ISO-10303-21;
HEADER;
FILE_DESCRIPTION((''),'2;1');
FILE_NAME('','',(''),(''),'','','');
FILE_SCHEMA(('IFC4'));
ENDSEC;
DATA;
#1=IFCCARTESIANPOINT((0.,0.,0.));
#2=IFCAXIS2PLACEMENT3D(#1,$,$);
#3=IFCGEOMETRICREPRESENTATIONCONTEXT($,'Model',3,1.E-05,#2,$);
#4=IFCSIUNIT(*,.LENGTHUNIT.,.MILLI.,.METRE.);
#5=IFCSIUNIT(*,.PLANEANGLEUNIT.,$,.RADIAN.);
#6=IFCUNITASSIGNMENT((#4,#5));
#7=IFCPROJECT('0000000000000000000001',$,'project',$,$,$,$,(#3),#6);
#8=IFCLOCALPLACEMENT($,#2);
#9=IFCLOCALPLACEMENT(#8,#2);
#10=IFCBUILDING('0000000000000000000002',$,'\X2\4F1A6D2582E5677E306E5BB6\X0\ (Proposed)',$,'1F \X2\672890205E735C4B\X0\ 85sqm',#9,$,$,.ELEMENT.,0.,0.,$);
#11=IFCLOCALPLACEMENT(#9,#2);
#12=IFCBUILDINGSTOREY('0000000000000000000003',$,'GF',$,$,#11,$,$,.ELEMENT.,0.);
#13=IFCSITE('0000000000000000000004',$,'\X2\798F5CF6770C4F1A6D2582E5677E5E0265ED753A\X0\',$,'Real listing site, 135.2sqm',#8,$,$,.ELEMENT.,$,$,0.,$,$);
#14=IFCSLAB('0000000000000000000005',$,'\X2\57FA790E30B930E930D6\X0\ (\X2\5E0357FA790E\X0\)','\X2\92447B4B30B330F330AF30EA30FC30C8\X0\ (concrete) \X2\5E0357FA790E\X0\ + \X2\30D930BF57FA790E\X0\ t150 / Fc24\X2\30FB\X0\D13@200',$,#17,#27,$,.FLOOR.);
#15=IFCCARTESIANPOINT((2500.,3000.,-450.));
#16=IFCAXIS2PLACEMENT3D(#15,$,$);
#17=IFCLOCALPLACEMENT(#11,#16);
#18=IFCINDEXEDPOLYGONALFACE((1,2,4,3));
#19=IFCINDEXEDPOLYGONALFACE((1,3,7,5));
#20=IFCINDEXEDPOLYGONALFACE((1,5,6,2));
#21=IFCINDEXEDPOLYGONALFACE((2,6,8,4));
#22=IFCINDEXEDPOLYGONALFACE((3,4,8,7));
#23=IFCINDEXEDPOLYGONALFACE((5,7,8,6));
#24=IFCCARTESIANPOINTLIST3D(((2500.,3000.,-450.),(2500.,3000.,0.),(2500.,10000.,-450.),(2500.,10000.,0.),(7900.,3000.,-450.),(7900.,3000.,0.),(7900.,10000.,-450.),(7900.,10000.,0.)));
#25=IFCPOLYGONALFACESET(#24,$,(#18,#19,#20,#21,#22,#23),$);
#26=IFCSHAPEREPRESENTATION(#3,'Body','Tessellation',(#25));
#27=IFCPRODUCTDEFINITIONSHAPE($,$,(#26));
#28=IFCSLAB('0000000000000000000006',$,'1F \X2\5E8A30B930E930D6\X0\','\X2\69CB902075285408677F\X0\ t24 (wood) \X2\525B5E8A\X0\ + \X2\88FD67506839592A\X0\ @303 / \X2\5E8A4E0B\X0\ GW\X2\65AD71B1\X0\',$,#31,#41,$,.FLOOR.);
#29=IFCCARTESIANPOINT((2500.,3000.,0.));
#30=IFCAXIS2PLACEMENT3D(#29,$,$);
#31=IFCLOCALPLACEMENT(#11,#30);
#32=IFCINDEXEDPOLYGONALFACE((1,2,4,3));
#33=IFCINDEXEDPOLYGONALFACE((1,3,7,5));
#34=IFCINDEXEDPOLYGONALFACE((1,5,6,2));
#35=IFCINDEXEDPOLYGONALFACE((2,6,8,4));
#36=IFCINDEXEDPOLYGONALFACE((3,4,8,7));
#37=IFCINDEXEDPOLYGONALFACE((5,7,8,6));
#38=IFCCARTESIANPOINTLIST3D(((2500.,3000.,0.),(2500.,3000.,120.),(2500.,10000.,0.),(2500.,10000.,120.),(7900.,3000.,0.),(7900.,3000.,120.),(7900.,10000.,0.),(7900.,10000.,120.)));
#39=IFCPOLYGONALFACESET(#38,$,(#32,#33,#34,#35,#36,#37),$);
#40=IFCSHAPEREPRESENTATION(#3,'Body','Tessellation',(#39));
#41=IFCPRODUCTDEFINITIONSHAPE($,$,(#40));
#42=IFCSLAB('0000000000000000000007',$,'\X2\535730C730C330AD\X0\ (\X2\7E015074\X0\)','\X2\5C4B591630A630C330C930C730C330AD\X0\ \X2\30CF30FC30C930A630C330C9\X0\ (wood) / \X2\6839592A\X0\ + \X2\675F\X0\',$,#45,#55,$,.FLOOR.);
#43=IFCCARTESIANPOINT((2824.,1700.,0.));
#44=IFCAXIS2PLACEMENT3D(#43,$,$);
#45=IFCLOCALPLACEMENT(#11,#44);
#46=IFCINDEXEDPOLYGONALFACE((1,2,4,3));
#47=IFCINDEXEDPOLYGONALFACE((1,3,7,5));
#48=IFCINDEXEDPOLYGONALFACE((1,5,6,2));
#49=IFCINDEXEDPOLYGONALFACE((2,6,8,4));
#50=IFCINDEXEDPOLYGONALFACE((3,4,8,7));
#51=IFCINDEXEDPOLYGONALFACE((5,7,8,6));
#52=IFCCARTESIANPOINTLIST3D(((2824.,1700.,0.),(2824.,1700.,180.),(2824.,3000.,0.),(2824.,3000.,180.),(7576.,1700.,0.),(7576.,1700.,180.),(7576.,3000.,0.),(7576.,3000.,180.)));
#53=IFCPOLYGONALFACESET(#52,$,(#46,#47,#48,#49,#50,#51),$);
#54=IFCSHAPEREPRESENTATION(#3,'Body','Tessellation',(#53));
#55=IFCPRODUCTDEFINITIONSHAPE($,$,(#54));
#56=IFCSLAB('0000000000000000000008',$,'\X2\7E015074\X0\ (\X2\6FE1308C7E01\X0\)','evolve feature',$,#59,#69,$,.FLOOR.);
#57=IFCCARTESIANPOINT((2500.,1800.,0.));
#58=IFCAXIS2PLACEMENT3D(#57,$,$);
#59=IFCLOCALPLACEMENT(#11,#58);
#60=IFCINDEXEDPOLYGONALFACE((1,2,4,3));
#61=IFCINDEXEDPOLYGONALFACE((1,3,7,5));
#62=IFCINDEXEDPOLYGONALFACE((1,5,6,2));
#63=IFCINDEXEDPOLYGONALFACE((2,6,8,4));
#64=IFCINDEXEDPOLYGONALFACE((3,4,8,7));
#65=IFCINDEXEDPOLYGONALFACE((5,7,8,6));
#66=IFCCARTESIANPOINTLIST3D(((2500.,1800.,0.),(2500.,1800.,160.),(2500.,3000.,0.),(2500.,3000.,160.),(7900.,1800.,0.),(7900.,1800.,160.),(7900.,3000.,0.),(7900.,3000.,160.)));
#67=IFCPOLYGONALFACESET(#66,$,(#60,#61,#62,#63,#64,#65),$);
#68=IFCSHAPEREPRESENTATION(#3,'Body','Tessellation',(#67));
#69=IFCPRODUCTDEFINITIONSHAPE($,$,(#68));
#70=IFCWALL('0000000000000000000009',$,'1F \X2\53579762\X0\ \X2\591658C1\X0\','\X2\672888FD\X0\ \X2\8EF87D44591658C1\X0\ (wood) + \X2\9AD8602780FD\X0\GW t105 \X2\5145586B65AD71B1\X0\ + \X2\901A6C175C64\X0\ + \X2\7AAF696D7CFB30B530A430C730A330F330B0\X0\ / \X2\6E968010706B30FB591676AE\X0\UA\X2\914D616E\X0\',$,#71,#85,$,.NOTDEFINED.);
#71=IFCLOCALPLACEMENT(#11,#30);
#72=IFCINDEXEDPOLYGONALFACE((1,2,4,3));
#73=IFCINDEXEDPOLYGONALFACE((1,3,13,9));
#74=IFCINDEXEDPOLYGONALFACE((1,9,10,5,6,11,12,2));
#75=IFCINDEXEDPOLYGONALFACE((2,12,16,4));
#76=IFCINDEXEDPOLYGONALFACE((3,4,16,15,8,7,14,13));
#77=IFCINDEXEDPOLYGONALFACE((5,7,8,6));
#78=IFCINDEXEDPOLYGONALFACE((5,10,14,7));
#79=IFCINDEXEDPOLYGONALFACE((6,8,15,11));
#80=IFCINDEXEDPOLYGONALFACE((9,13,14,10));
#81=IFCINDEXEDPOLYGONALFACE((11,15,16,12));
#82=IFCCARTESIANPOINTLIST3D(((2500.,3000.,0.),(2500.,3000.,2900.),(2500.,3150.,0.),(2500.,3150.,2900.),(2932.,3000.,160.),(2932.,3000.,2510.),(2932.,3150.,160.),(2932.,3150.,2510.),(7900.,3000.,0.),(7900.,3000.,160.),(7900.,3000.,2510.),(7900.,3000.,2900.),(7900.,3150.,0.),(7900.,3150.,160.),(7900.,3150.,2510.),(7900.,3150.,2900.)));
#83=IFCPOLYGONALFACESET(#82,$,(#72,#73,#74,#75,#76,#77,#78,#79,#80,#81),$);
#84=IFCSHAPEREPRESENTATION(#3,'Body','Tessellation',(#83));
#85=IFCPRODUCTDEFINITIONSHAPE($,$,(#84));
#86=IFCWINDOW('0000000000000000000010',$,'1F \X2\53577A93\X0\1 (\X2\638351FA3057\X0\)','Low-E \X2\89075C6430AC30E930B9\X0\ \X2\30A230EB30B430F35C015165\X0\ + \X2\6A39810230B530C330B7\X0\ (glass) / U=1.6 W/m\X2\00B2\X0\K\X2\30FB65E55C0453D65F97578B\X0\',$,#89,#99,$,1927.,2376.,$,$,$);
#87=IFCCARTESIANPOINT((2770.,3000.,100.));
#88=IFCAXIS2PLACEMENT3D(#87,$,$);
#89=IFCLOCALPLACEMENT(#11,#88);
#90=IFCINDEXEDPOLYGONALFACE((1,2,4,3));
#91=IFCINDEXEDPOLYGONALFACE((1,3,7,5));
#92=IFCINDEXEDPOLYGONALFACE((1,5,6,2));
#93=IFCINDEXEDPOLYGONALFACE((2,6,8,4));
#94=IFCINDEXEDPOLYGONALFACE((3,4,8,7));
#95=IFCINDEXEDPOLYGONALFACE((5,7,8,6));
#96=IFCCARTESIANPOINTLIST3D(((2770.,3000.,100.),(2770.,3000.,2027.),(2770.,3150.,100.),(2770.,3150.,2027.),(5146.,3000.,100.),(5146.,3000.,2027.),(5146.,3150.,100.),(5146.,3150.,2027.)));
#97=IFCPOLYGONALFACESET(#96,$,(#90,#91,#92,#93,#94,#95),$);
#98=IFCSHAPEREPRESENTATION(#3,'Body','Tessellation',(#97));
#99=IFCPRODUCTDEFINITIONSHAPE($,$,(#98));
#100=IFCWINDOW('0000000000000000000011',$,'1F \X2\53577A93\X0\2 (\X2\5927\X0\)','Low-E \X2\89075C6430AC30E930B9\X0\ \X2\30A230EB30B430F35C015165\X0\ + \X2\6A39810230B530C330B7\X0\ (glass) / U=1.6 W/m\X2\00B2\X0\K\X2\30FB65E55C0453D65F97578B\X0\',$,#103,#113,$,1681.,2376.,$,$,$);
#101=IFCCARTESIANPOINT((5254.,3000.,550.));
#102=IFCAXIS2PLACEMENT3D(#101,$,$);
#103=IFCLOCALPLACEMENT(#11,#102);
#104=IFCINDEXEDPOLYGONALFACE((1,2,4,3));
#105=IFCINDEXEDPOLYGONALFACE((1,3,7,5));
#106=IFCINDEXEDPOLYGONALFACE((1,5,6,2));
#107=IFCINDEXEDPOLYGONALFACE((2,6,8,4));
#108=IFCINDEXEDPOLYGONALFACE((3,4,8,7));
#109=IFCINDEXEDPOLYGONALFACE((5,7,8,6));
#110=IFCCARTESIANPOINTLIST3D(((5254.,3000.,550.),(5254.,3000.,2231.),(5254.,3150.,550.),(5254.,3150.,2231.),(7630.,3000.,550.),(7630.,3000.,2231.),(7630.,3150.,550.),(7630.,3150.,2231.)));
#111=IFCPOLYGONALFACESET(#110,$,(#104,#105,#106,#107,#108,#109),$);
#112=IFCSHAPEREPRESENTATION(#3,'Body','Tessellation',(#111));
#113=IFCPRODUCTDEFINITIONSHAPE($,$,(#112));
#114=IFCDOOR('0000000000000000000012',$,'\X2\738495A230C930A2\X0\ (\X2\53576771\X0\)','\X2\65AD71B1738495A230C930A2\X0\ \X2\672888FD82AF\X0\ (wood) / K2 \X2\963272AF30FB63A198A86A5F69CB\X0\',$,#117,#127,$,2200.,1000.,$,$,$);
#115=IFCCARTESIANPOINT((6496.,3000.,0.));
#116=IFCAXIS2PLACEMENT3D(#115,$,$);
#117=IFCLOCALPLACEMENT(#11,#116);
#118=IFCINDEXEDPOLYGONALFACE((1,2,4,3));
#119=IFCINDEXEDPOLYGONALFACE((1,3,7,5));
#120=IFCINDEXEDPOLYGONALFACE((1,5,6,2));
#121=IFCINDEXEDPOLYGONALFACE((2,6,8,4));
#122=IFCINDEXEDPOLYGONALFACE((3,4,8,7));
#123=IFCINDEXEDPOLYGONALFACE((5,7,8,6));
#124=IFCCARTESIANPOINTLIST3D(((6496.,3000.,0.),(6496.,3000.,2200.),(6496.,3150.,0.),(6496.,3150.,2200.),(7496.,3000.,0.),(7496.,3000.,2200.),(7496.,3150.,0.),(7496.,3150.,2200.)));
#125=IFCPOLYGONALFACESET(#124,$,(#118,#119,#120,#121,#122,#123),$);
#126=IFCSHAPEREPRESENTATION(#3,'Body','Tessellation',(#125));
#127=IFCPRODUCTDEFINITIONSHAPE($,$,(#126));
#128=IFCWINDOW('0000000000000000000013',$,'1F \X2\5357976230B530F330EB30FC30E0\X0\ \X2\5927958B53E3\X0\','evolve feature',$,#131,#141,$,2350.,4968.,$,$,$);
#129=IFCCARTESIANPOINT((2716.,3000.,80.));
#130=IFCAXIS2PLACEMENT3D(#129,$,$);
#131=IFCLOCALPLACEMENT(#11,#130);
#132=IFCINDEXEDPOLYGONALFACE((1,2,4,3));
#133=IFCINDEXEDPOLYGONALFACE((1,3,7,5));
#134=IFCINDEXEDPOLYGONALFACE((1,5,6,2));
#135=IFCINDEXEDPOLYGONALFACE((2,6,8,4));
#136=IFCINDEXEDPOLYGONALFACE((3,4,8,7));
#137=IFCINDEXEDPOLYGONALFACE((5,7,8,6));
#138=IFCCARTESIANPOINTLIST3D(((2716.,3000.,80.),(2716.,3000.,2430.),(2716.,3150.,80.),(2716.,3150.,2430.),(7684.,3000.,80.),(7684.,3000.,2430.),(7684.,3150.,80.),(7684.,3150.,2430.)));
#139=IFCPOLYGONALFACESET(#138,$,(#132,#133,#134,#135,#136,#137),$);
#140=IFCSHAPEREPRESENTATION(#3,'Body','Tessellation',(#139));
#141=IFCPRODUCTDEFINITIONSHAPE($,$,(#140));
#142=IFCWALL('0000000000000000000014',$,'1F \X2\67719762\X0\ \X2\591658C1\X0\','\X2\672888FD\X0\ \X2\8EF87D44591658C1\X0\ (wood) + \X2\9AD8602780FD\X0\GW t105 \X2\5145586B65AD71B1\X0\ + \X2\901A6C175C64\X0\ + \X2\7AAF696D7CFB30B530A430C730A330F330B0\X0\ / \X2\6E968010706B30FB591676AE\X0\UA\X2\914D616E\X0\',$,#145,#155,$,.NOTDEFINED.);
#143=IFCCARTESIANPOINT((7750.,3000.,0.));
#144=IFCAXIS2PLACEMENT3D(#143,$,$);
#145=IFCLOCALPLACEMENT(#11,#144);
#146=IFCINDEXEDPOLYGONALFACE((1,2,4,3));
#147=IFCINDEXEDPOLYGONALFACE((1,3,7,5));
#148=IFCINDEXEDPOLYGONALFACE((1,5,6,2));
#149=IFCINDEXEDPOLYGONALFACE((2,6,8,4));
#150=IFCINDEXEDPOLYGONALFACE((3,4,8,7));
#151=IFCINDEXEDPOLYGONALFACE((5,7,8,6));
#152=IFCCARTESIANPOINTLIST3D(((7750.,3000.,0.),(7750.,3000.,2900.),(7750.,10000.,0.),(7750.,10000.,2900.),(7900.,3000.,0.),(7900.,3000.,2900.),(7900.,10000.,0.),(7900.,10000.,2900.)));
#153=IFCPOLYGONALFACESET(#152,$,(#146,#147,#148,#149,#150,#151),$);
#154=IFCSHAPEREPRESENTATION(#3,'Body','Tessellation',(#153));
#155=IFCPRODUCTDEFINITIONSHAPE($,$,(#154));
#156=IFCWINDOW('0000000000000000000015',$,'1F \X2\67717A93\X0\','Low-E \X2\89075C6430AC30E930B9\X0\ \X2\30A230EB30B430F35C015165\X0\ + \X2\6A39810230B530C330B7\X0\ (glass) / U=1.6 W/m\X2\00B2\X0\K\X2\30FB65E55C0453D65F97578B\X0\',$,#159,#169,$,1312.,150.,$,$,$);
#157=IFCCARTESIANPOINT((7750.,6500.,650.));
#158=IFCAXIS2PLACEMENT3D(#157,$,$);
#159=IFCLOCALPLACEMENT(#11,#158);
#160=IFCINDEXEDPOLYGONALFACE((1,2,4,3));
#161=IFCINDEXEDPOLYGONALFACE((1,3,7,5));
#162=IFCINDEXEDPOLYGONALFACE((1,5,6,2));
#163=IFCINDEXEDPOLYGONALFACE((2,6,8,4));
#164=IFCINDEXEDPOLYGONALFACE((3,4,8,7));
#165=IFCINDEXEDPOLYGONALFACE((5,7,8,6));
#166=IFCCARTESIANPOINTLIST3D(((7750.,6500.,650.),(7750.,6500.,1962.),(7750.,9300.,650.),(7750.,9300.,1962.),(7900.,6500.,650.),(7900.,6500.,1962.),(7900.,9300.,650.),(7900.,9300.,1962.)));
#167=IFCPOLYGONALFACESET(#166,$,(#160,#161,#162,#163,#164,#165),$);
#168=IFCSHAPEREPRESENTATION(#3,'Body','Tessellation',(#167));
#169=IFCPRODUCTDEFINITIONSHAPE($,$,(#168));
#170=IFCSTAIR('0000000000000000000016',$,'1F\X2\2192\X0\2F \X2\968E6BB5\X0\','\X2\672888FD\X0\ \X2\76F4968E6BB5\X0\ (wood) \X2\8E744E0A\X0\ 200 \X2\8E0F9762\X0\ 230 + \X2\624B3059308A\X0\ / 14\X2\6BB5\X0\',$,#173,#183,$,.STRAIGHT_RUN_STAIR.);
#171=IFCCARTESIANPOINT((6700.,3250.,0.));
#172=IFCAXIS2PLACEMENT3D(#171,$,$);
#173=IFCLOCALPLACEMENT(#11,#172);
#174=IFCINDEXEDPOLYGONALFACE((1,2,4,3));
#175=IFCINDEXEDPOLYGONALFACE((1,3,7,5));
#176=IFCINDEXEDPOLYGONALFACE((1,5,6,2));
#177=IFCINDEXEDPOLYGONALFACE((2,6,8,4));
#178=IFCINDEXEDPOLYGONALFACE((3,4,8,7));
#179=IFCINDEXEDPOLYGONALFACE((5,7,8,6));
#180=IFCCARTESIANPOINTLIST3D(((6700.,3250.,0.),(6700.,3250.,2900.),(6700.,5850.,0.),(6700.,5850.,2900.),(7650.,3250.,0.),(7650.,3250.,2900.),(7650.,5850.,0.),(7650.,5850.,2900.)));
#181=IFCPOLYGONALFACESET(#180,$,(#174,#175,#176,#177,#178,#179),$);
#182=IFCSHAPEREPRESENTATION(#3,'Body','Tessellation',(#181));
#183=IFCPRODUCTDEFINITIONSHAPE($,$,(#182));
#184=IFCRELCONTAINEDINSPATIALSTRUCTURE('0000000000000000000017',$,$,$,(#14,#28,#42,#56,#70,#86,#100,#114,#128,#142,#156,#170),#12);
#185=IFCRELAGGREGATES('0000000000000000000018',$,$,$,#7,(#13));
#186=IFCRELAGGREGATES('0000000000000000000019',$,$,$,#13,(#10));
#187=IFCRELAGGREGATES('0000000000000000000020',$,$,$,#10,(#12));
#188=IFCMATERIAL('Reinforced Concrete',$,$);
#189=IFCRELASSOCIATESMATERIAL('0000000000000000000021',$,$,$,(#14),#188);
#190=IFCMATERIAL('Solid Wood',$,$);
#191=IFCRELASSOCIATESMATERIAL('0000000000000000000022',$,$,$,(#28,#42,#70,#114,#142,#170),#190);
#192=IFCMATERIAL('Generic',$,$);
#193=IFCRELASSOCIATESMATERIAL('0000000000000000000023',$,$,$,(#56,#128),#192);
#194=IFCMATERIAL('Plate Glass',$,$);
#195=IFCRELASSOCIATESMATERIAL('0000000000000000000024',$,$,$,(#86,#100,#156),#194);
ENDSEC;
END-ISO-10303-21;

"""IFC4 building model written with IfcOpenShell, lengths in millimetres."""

from ifc_helpers import new_model, si_unit, frame, frame_2d, origin, place, context, project, spatial, rectangle, extrude, material, element, fill, save


model = new_model("IFC4")

# Units and contexts
model_context = context("Model", 3, precision=1e-05, world=origin())
ifc_project = project(units=[si_unit("LENGTHUNIT", "METRE", prefix="MILLI"), si_unit("PLANEANGLEUNIT", "RADIAN")], contexts=[model_context])

# Site, building, storey
site_placement = place(None, origin())
site = spatial("IfcSite", under=ifc_project, at=site_placement, Name="福島県会津若松市旭町", ObjectType="Real listing site, 135.2sqm", CompositionType="ELEMENT", RefElevation=0.0)
building_placement = place(site_placement, origin())
building = spatial("IfcBuilding", under=site, at=building_placement, Name="会津若松の家 (Proposed)", ObjectType="1F 木造平屋 85sqm", CompositionType="ELEMENT", ElevationOfRefHeight=0.0, ElevationOfTerrain=0.0)
storey_placement = place(building_placement, origin())
storey = spatial("IfcBuildingStorey", under=building, at=storey_placement, Name="GF", CompositionType="ELEMENT", Elevation=0.0)

# Slabs
ifc_material_1 = material(Name="Reinforced Concrete")
slab_1_placement = place(storey_placement, frame((2500.0, 3000.0, -450.0)))
element("IfcSlab", 1, at=slab_1_placement, inside=storey, material=ifc_material_1, Name="基礎スラブ (布基礎)", Description="鉄筋コンクリート (concrete) 布基礎 + ベタ基礎 t150 / Fc24・D13@200", PredefinedType="FLOOR", context=model_context, shape_type="SweptSolid", body=[
    extrude(rectangle(XDim=5400.0, YDim=7000.0, at=frame_2d((2700.0, 3500.0))), frame((2500.0, 3000.0, -450.0)), (0.0, 0.0, 1.0), 450.0),
])
ifc_material_2 = material(Name="Solid Wood")
slab_2_placement = place(storey_placement, frame((2500.0, 3000.0, 0.0)))
element("IfcSlab", 2, at=slab_2_placement, inside=storey, material=ifc_material_2, Name="1F 床スラブ", Description="構造用合板 t24 (wood) 剛床 + 製材根太 @303 / 床下 GW断熱", PredefinedType="FLOOR", context=model_context, shape_type="SweptSolid", body=[
    extrude(rectangle(XDim=5400.0, YDim=7000.0, at=frame_2d((2700.0, 3500.0))), frame((2500.0, 3000.0, 0.0)), (0.0, 0.0, 1.0), 120.0),
])
slab_3_placement = place(storey_placement, frame((2824.0, 1700.0, 0.0)))
element("IfcSlab", 3, at=slab_3_placement, inside=storey, material=ifc_material_2, Name="南デッキ (縁側)", Description="屋外ウッドデッキ ハードウッド (wood) / 根太 + 束", PredefinedType="FLOOR", context=model_context, shape_type="SweptSolid", body=[
    extrude(rectangle(XDim=4752.0, YDim=1300.0, at=frame_2d((2376.0, 650.0))), frame((2824.0, 1700.0, 0.0)), (0.0, 0.0, 1.0), 180.0),
])
ifc_material_3 = material(Name="Generic")
slab_4_placement = place(storey_placement, frame((2500.0, 1800.0, 0.0)))
element("IfcSlab", 4, at=slab_4_placement, inside=storey, material=ifc_material_3, Name="縁側 (濡れ縁)", Description="evolve feature", PredefinedType="FLOOR", context=model_context, shape_type="SweptSolid", body=[
    extrude(rectangle(XDim=5400.0, YDim=1200.0, at=frame_2d((2700.0, 600.0))), frame((2500.0, 1800.0, 0.0)), (0.0, 0.0, 1.0), 160.0),
])

# Wall, openings, windows, door
wall_1_placement = place(storey_placement, frame((2500.0, 3000.0, 0.0)))
wall_1 = element("IfcWall", 5, at=wall_1_placement, inside=storey, material=ifc_material_2, Name="1F 南面 外壁", Description="木製 軸組外壁 (wood) + 高性能GW t105 充填断熱 + 通気層 + 窯業系サイディング / 準耐火・外皮UA配慮", PredefinedType="NOTDEFINED", context=model_context, shape_type="SweptSolid", body=[
    extrude(rectangle(XDim=5400.0, YDim=150.0, at=frame_2d((2700.0, 75.0))), frame((2500.0, 3000.0, 0.0)), (0.0, 0.0, 1.0), 2900.0),
])
opening_1_placement = place(storey_placement, frame((2770.0, 3000.0, 100.0)))
opening_1 = element("IfcOpeningElement", 6, at=opening_1_placement, cuts=wall_1, PredefinedType="NOTDEFINED", context=model_context, shape_type="SweptSolid", body=[
    extrude(rectangle(XDim=2376.0, YDim=150.0, at=frame_2d((1188.0, 75.0))), frame((2770.0, 3000.0, 100.0)), (0.0, 0.0, 1.0), 1927.0),
])
opening_2_placement = place(storey_placement, frame((5254.0, 3000.0, 550.0)))
opening_2 = element("IfcOpeningElement", 7, at=opening_2_placement, cuts=wall_1, PredefinedType="NOTDEFINED", context=model_context, shape_type="SweptSolid", body=[
    extrude(rectangle(XDim=2376.0, YDim=150.0, at=frame_2d((1188.0, 75.0))), frame((5254.0, 3000.0, 550.0)), (0.0, 0.0, 1.0), 1681.0),
])
opening_3_placement = place(storey_placement, frame((6496.0, 3000.0, 0.0)))
opening_3 = element("IfcOpeningElement", 8, at=opening_3_placement, cuts=wall_1, PredefinedType="NOTDEFINED", context=model_context, shape_type="SweptSolid", body=[
    extrude(rectangle(XDim=1000.0, YDim=150.0, at=frame_2d((500.0, 75.0))), frame((6496.0, 3000.0, 0.0)), (0.0, 0.0, 1.0), 2200.0),
])
opening_4_placement = place(storey_placement, frame((2716.0, 3000.0, 80.0)))
opening_4 = element("IfcOpeningElement", 9, at=opening_4_placement, cuts=wall_1, PredefinedType="NOTDEFINED", context=model_context, shape_type="SweptSolid", body=[
    extrude(rectangle(XDim=4968.0, YDim=150.0, at=frame_2d((2484.0, 75.0))), frame((2716.0, 3000.0, 80.0)), (0.0, 0.0, 1.0), 2350.0),
])
ifc_material_4 = material(Name="Plate Glass")
window_1_placement = place(storey_placement, frame((2770.0, 3000.0, 100.0)))
window_1 = element("IfcWindow", 10, at=window_1_placement, inside=storey, material=ifc_material_4, Name="1F 南窓1 (掃出し)", Description="Low-E 複層ガラス アルゴン封入 + 樹脂サッシ (glass) / U=1.6 W/m²K・日射取得型", OverallHeight=1927.0, OverallWidth=2376.0, context=model_context, shape_type="SweptSolid", body=[
    extrude(rectangle(XDim=2376.0, YDim=150.0, at=frame_2d((1188.0, 75.0))), frame((2770.0, 3000.0, 100.0)), (0.0, 0.0, 1.0), 1927.0),
])
fill(opening_1, window_1)
window_2_placement = place(storey_placement, frame((5254.0, 3000.0, 550.0)))
window_2 = element("IfcWindow", 11, at=window_2_placement, inside=storey, material=ifc_material_4, Name="1F 南窓2 (大)", Description="Low-E 複層ガラス アルゴン封入 + 樹脂サッシ (glass) / U=1.6 W/m²K・日射取得型", OverallHeight=1681.0, OverallWidth=2376.0, context=model_context, shape_type="SweptSolid", body=[
    extrude(rectangle(XDim=2376.0, YDim=150.0, at=frame_2d((1188.0, 75.0))), frame((5254.0, 3000.0, 550.0)), (0.0, 0.0, 1.0), 1681.0),
])
fill(opening_2, window_2)
door_placement = place(storey_placement, frame((6496.0, 3000.0, 0.0)))
door = element("IfcDoor", 12, at=door_placement, inside=storey, material=ifc_material_2, Name="玄関ドア (南東)", Description="断熱玄関ドア 木製芯 (wood) / K2 防犯・採風機構", OverallHeight=2200.0, OverallWidth=1000.0, context=model_context, shape_type="SweptSolid", body=[
    extrude(rectangle(XDim=1000.0, YDim=150.0, at=frame_2d((500.0, 75.0))), frame((6496.0, 3000.0, 0.0)), (0.0, 0.0, 1.0), 2200.0),
])
fill(opening_3, door)
window_3_placement = place(storey_placement, frame((2716.0, 3000.0, 80.0)))
window_3 = element("IfcWindow", 13, at=window_3_placement, inside=storey, material=ifc_material_3, Name="1F 南面サンルーム 大開口", Description="evolve feature", OverallHeight=2350.0, OverallWidth=4968.0, context=model_context, shape_type="SweptSolid", body=[
    extrude(rectangle(XDim=4968.0, YDim=150.0, at=frame_2d((2484.0, 75.0))), frame((2716.0, 3000.0, 80.0)), (0.0, 0.0, 1.0), 2350.0),
])
fill(opening_4, window_3)

# Wall, opening, window
wall_2_placement = place(storey_placement, frame((7750.0, 3000.0, 0.0)))
wall_2 = element("IfcWall", 14, at=wall_2_placement, inside=storey, material=ifc_material_2, Name="1F 東面 外壁", Description="木製 軸組外壁 (wood) + 高性能GW t105 充填断熱 + 通気層 + 窯業系サイディング / 準耐火・外皮UA配慮", PredefinedType="NOTDEFINED", context=model_context, shape_type="SweptSolid", body=[
    extrude(rectangle(XDim=150.0, YDim=7000.0, at=frame_2d((75.0, 3500.0))), frame((7750.0, 3000.0, 0.0)), (0.0, 0.0, 1.0), 2900.0),
])
opening_5_placement = place(storey_placement, frame((7750.0, 6500.0, 650.0)))
opening_5 = element("IfcOpeningElement", 15, at=opening_5_placement, cuts=wall_2, PredefinedType="NOTDEFINED", context=model_context, shape_type="SweptSolid", body=[
    extrude(rectangle(XDim=150.0, YDim=2800.0, at=frame_2d((75.0, 1400.0))), frame((7750.0, 6500.0, 650.0)), (0.0, 0.0, 1.0), 1312.0),
])
window_4_placement = place(storey_placement, frame((7750.0, 6500.0, 650.0)))
window_4 = element("IfcWindow", 16, at=window_4_placement, inside=storey, material=ifc_material_4, Name="1F 東窓", Description="Low-E 複層ガラス アルゴン封入 + 樹脂サッシ (glass) / U=1.6 W/m²K・日射取得型", OverallHeight=1312.0, OverallWidth=150.0, context=model_context, shape_type="SweptSolid", body=[
    extrude(rectangle(XDim=150.0, YDim=2800.0, at=frame_2d((75.0, 1400.0))), frame((7750.0, 6500.0, 650.0)), (0.0, 0.0, 1.0), 1312.0),
])
fill(opening_5, window_4)

# Stair
stair_placement = place(storey_placement, frame((6700.0, 3250.0, 0.0)))
element("IfcStair", 17, at=stair_placement, inside=storey, material=ifc_material_2, Name="1F→2F 階段", Description="木製 直階段 (wood) 蹴上 200 踏面 230 + 手すり / 14段", PredefinedType="STRAIGHT_RUN_STAIR", context=model_context, shape_type="SweptSolid", body=[
    extrude(rectangle(XDim=950.0, YDim=2600.0, at=frame_2d((475.0, 1300.0))), frame((6700.0, 3250.0, 0.0)), (0.0, 0.0, 1.0), 2900.0),
])

save(model, "model.ifc")
